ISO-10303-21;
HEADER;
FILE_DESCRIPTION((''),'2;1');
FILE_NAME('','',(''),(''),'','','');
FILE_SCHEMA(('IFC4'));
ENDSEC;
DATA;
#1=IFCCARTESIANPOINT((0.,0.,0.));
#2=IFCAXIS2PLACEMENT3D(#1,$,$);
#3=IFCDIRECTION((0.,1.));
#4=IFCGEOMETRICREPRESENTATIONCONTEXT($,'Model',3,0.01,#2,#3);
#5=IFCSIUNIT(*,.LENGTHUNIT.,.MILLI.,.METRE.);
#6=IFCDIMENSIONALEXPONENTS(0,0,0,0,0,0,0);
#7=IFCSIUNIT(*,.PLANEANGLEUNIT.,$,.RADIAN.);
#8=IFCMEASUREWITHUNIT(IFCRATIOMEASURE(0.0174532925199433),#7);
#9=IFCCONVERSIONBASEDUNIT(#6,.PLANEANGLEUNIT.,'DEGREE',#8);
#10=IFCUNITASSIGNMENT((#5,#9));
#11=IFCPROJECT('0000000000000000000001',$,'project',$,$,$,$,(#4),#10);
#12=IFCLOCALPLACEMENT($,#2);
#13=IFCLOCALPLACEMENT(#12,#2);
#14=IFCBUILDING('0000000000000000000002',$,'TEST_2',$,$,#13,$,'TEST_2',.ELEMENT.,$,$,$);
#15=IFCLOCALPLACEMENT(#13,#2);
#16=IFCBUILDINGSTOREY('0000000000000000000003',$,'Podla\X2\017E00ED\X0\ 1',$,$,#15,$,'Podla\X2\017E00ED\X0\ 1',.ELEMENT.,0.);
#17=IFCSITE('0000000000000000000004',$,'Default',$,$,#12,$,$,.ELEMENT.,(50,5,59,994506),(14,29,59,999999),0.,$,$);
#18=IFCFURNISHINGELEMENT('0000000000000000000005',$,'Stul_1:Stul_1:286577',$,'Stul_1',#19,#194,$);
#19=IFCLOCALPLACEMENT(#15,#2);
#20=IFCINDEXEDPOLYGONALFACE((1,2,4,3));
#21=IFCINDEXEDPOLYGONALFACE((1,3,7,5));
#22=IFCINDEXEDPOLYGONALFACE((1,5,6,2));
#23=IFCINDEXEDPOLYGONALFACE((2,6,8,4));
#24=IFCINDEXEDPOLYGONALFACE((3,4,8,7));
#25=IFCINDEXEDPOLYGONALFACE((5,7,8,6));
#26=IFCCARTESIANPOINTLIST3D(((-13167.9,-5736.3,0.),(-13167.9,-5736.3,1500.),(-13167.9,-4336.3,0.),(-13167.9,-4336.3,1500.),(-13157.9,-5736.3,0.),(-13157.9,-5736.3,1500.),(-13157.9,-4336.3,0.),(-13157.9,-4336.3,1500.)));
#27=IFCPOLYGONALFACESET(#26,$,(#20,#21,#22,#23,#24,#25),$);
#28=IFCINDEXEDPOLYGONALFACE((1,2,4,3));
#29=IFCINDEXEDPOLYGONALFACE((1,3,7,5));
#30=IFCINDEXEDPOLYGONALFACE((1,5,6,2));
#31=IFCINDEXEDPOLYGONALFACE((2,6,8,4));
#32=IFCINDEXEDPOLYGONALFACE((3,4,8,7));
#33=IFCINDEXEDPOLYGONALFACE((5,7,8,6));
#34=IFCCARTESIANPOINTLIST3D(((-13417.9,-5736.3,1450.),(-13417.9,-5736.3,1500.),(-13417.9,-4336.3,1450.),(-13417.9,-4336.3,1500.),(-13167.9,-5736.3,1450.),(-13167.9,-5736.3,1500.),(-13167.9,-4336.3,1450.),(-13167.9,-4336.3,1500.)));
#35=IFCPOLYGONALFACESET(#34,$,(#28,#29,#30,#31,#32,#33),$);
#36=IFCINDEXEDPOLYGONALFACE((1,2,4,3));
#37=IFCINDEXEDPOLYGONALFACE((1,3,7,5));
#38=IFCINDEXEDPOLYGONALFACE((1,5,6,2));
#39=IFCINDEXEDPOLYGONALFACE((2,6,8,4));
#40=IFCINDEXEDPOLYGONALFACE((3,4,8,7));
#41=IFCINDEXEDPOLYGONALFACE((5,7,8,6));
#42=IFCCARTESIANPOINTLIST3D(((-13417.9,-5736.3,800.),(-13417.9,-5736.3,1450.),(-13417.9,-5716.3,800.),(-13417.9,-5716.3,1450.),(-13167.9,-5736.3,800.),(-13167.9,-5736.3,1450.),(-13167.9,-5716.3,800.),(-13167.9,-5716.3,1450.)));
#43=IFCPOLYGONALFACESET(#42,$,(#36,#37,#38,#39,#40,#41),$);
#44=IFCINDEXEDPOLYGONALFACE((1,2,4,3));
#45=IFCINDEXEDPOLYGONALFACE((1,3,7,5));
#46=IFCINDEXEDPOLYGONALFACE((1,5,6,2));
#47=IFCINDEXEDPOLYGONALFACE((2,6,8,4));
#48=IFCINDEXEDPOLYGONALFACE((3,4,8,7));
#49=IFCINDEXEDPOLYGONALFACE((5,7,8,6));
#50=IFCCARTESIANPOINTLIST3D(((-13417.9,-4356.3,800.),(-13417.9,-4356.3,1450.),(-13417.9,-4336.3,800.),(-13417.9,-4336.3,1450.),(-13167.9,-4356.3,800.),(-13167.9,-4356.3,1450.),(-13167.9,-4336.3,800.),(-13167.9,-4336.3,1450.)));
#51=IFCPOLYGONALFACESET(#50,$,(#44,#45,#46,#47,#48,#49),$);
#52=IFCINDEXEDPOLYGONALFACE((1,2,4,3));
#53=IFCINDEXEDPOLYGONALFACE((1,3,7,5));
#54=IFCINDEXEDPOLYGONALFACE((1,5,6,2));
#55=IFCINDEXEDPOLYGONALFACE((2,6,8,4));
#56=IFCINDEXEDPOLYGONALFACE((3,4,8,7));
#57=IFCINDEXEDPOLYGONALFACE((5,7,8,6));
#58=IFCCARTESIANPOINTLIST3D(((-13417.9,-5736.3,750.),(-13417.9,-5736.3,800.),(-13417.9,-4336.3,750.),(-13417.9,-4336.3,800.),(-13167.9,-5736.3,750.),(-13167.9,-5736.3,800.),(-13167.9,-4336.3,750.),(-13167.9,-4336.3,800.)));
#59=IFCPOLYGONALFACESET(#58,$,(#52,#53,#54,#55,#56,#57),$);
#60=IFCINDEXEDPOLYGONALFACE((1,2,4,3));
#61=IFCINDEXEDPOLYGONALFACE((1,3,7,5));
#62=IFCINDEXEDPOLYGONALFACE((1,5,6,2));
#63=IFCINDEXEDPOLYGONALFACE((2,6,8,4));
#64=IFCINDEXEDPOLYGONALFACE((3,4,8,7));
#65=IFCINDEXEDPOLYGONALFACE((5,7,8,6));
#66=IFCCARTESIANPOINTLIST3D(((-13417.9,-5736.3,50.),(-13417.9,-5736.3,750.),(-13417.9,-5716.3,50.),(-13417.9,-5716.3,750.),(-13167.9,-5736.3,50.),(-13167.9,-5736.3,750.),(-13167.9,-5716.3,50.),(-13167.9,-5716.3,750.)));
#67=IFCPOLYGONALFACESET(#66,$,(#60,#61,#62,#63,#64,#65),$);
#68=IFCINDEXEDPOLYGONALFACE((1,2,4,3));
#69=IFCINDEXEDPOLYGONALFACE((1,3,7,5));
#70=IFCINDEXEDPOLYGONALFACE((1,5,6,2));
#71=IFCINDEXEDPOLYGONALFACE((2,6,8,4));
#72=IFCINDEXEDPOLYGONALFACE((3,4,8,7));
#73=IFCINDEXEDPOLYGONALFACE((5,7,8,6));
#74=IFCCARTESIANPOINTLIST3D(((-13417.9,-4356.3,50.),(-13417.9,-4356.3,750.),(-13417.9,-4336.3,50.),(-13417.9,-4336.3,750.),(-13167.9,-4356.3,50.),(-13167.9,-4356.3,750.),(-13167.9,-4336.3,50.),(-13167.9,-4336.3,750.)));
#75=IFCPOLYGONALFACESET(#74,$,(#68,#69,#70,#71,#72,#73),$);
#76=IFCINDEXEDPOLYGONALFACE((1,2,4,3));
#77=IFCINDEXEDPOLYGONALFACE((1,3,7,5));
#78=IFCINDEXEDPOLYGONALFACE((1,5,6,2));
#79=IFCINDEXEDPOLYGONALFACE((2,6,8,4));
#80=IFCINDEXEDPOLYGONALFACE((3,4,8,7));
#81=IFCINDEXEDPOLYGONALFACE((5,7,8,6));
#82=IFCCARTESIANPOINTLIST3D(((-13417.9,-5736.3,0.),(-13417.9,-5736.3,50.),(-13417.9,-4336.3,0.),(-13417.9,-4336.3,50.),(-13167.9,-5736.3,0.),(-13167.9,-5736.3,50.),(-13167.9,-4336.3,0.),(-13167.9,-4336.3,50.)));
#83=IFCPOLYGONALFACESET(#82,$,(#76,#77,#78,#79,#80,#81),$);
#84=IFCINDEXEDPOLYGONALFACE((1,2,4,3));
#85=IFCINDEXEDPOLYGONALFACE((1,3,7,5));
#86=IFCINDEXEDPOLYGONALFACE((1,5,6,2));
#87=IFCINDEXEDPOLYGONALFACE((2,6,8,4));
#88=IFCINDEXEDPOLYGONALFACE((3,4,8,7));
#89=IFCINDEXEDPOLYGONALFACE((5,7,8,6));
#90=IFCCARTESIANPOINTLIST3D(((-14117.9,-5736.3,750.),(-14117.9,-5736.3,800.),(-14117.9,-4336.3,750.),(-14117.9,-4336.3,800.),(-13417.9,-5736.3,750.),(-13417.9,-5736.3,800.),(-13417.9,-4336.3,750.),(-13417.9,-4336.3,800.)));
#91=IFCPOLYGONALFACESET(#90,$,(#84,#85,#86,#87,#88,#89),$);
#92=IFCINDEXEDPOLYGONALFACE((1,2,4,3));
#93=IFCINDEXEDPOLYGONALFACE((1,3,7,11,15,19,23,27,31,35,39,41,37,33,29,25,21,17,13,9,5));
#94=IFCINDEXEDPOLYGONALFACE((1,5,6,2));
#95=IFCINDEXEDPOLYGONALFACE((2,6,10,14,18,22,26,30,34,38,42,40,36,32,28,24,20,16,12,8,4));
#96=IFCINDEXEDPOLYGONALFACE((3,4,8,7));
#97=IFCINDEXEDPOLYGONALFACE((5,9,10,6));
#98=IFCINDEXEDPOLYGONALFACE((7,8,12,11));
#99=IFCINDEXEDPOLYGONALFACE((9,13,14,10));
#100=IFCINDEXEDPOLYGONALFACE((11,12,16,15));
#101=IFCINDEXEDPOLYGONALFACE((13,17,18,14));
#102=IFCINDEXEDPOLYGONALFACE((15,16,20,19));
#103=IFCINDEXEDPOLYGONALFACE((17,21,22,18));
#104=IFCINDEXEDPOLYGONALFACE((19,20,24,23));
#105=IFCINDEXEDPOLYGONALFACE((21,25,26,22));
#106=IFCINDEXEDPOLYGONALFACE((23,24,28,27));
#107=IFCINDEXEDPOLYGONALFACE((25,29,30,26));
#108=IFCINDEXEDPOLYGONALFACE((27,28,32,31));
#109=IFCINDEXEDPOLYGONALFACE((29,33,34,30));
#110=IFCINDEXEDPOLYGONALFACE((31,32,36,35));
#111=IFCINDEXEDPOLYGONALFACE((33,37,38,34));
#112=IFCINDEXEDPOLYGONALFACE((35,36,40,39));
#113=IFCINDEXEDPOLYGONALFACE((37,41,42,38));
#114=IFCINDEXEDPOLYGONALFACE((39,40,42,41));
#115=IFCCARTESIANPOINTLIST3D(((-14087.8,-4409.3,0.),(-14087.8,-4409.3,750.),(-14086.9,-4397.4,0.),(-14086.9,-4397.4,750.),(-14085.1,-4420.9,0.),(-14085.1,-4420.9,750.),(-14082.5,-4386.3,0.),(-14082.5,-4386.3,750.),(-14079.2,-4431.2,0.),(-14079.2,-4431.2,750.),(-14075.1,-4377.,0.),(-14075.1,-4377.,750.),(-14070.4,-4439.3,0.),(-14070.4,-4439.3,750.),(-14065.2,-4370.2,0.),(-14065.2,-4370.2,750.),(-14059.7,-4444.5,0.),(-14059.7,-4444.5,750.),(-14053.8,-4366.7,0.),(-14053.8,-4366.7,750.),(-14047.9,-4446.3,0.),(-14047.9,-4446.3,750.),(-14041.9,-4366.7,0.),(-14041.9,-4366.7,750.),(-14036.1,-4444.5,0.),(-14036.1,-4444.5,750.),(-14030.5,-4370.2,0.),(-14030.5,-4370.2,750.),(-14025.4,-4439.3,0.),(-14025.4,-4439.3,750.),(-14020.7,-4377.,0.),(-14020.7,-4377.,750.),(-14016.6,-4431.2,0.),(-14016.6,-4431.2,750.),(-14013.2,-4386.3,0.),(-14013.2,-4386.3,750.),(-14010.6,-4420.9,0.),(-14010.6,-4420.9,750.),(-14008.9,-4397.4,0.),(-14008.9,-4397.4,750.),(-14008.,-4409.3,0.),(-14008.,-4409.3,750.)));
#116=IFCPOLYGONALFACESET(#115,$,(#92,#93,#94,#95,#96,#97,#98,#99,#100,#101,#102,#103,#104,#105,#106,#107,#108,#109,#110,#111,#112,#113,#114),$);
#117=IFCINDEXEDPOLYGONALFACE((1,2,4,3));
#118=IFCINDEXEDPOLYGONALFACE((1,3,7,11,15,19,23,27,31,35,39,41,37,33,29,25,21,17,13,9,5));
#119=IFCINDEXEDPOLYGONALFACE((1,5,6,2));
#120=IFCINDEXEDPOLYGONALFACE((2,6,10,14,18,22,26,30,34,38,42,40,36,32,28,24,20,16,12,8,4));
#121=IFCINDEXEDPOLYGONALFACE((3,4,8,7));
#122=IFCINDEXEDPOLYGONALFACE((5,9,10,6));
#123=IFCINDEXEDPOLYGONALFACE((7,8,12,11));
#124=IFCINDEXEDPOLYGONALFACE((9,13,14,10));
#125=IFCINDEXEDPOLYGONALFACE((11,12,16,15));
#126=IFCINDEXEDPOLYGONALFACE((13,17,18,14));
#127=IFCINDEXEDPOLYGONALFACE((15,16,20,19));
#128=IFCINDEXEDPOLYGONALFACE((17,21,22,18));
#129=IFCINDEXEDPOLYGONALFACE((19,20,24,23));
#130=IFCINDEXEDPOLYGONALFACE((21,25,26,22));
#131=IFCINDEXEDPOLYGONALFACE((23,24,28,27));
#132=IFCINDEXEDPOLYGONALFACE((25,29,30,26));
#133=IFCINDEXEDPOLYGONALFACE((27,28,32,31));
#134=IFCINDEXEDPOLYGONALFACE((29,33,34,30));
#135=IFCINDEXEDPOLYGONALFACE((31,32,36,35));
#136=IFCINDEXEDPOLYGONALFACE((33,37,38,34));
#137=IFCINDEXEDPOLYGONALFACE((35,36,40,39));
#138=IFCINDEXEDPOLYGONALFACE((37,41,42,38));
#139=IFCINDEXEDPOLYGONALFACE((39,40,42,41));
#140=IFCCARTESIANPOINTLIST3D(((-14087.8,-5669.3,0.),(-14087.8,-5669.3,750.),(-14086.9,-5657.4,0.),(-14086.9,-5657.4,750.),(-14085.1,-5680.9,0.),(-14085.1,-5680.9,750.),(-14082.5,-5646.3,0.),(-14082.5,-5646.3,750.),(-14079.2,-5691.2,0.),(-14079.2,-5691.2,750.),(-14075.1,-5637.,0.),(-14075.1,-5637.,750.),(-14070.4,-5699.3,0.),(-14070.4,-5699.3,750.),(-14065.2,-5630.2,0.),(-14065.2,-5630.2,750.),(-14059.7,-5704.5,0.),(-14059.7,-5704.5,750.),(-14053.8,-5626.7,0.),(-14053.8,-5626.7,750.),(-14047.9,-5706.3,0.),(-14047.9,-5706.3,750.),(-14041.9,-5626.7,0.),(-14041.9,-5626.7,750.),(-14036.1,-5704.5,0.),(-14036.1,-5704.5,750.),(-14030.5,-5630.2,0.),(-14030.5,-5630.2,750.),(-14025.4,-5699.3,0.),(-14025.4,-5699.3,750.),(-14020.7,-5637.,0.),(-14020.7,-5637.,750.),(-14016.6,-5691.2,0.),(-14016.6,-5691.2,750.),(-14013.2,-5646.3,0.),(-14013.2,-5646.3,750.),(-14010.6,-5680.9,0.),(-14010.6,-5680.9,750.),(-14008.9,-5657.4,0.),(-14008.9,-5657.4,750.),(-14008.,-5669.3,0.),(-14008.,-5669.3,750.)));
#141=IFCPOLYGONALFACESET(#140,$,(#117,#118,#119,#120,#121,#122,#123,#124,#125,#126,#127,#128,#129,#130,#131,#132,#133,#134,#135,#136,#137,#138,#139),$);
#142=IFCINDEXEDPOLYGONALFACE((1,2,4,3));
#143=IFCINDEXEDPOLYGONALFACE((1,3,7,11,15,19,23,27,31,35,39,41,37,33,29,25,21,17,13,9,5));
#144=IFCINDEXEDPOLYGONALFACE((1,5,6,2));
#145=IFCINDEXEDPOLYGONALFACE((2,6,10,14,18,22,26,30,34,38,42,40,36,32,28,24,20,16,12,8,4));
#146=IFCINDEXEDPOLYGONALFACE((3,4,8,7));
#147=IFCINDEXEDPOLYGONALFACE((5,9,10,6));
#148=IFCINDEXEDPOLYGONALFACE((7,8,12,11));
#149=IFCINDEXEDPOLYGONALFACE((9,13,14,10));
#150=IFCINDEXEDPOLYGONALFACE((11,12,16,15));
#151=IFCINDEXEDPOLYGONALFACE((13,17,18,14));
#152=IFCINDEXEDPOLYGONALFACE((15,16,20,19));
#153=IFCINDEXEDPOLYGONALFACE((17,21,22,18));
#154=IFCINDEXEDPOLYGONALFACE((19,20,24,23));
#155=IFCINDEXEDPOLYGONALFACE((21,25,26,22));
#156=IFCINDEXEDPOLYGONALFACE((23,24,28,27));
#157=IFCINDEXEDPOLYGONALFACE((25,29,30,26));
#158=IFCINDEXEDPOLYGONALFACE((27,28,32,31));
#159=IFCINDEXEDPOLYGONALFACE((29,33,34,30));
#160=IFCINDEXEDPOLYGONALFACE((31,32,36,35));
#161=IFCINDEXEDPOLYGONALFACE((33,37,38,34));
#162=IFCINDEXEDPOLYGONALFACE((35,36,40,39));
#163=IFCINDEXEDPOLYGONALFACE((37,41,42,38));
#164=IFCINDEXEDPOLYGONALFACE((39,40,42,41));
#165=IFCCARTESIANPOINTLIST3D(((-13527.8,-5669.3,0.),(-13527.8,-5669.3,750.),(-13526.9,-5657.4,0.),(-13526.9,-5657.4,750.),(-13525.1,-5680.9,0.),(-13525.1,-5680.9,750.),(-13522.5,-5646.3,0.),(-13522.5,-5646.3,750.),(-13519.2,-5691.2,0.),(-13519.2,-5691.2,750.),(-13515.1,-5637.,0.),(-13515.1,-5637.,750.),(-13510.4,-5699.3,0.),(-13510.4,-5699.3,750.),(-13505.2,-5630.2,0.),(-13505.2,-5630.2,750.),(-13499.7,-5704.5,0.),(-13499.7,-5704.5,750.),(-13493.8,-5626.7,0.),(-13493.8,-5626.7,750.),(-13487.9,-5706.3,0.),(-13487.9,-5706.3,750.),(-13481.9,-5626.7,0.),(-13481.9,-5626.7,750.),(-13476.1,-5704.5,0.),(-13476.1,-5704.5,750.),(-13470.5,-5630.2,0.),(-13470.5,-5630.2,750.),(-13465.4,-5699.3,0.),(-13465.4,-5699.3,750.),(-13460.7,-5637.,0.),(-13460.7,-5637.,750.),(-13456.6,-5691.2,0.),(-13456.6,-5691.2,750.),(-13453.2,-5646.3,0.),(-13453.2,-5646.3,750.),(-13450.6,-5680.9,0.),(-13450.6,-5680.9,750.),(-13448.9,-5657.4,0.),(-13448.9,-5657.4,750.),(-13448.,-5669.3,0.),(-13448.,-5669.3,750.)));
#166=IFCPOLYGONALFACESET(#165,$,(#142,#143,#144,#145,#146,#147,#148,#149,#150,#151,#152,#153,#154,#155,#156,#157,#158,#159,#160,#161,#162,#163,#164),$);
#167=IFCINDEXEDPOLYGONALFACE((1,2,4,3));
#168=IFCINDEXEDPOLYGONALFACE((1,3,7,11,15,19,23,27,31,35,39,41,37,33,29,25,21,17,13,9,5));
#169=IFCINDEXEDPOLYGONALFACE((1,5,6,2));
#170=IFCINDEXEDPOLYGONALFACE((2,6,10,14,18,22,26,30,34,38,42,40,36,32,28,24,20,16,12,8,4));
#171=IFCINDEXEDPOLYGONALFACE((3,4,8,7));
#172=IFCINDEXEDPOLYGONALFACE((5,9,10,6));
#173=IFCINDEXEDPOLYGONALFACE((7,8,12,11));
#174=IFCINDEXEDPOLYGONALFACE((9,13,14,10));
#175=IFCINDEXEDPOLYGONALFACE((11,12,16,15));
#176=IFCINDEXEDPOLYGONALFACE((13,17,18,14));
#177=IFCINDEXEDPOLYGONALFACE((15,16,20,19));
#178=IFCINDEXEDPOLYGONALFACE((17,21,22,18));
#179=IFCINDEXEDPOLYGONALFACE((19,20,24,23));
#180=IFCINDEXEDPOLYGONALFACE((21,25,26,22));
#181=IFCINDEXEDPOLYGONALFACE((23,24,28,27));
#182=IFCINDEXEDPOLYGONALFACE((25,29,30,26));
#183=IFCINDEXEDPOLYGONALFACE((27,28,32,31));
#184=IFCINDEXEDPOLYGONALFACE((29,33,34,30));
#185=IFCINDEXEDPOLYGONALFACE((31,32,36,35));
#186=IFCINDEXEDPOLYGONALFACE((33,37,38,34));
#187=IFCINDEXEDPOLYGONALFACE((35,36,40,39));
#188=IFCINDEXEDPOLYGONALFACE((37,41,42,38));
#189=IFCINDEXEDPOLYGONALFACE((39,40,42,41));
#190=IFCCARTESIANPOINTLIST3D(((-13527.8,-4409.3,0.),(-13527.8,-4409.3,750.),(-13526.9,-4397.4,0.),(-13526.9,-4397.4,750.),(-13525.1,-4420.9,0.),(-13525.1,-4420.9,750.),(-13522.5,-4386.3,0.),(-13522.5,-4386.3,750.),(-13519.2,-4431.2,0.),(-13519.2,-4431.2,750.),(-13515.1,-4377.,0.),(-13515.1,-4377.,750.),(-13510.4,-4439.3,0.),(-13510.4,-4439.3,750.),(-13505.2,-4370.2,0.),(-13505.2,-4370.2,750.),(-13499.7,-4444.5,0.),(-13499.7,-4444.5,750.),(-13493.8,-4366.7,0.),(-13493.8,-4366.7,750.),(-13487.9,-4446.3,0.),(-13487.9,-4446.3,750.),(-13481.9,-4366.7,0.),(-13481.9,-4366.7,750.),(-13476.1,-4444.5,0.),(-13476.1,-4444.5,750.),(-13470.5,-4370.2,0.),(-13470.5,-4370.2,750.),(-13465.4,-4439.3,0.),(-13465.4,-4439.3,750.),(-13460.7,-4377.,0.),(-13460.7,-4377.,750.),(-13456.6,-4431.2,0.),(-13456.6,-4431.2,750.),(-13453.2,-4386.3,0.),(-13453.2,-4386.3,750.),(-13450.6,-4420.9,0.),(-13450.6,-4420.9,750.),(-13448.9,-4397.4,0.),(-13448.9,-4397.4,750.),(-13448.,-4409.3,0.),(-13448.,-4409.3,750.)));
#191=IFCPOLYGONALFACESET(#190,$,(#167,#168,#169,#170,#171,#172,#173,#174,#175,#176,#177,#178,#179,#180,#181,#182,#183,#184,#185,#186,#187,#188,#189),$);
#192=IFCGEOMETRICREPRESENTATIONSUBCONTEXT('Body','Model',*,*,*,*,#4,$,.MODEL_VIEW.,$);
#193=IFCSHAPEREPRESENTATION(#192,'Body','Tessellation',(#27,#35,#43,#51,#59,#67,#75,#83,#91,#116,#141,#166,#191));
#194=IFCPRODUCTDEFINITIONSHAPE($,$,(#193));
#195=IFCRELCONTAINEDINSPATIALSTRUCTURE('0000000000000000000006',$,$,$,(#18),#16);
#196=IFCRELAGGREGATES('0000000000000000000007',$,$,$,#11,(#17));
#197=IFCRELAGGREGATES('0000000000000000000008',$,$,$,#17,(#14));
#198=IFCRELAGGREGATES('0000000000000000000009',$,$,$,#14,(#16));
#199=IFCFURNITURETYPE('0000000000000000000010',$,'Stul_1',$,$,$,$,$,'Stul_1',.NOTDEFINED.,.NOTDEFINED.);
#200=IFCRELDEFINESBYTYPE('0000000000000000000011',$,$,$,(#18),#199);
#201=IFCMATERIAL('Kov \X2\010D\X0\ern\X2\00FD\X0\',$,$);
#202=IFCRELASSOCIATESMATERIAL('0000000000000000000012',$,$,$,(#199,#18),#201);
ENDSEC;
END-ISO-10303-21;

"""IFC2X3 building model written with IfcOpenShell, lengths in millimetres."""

from ifc_helpers import new_model, entity, si_unit, converted_unit, direction, frame, frame_2d, origin, origin_2d_with_axis, place, context, subcontext, project, spatial, rectangle, circle, extrude, source, transform, mapped, material, type_object, type_shapes, element, save


model = new_model("IFC2X3")

# Units and contexts
model_context = context("Model", 3, precision=0.01, world=origin(), true_north=direction((0.0, 1.0)))
body_context = subcontext(model_context, "Body", "Model", "MODEL_VIEW")
ifc_project = project(units=[si_unit("LENGTHUNIT", "METRE", prefix="MILLI"), converted_unit("PLANEANGLEUNIT", "DEGREE", entity("IfcRatioMeasure", 0.0174532925199433), si_unit("PLANEANGLEUNIT", "RADIAN"), dimensions=[0, 0, 0, 0, 0, 0, 0])], contexts=[model_context])

# Site, building, storey
site_placement = place(None, origin())
site = spatial("IfcSite", under=ifc_project, at=site_placement, Name="Default", CompositionType="ELEMENT", RefLatitude=(50, 5, 59, 994506), RefLongitude=(14, 29, 59, 999999), RefElevation=0.0)
building_placement = place(site_placement, origin())
building = spatial("IfcBuilding", under=site, at=building_placement, Name="TEST_2", LongName="TEST_2", CompositionType="ELEMENT")
storey_placement = place(building_placement, origin())
storey = spatial("IfcBuildingStorey", under=building, at=storey_placement, Name="Podlaží 1", LongName="Podlaží 1", CompositionType="ELEMENT", Elevation=0.0)

# Furnishing element
ifc_material_1 = material(Name="Kov černý")
furniture_type = type_object("IfcFurnitureType", Name="Stul_1", ElementType="Stul_1", material=ifc_material_1)
shared_shape_1 = source(origin(), body_context, "Body", "SweptSolid", [
    extrude(rectangle(XDim=1400.0, YDim=10.0, at=origin_2d_with_axis()), frame((0.0, 605.0, 0.0), z_axis=(0.0, 0.0, 1.0), x_axis=(-1.0, 0.0, 0.0)), (0.0, 0.0, 1.0), 1500.0),
    extrude(rectangle(XDim=1400.0, YDim=250.0, at=frame_2d((0.0, 0.0), x_axis=(1.0, 0.0))), frame((0.0, 475.0, 1450.0), z_axis=(0.0, 0.0, 1.0), x_axis=(-1.0, 0.0, 0.0)), (0.0, 0.0, 1.0), 50.0),
    extrude(rectangle(XDim=20.0, YDim=250.0, at=origin_2d_with_axis()), frame((690.0, 475.0, 800.0), z_axis=(0.0, 0.0, 1.0), x_axis=(-1.0, 0.0, 0.0)), (0.0, 0.0, 1.0), 650.0),
    extrude(rectangle(XDim=20.0, YDim=250.0, at=frame_2d((0.0, 0.0), x_axis=(1.0, 0.0))), frame((-690.0, 475.0, 800.0), z_axis=(0.0, 0.0, 1.0), x_axis=(-1.0, 0.0, 0.0)), (0.0, 0.0, 1.0), 650.0),
    extrude(rectangle(XDim=1400.0, YDim=250.0, at=origin_2d_with_axis()), frame((0.0, 475.0, 750.0), z_axis=(0.0, 0.0, 1.0), x_axis=(-1.0, 0.0, 0.0)), (0.0, 0.0, 1.0), 50.0),
    extrude(rectangle(XDim=20.0, YDim=250.0, at=origin_2d_with_axis()), frame((690.0, 475.0, 50.0), z_axis=(0.0, 0.0, 1.0), x_axis=(-1.0, 0.0, 0.0)), (0.0, 0.0, 1.0), 700.0),
    extrude(rectangle(XDim=20.0, YDim=250.0, at=frame_2d((0.0, 0.0), x_axis=(1.0, 0.0))), frame((-690.0, 475.0, 50.0), z_axis=(0.0, 0.0, 1.0), x_axis=(-1.0, 0.0, 0.0)), (0.0, 0.0, 1.0), 700.0),
    extrude(rectangle(XDim=1400.0, YDim=250.0, at=origin_2d_with_axis()), frame((0.0, 475.0, 0.0), z_axis=(0.0, 0.0, 1.0), x_axis=(-1.0, 0.0, 0.0)), (0.0, 0.0, 1.0), 50.0),
    extrude(rectangle(XDim=1400.0, YDim=700.0, at=origin_2d_with_axis()), frame((0.0, 0.0, 750.0), z_axis=(0.0, 0.0, 1.0), x_axis=(-1.0, 0.0, 0.0)), (0.0, 0.0, 1.0), 50.0),
    extrude(circle(Radius=40.0, at=frame_2d((0.0, 0.0), x_axis=(1.0, 0.0))), frame((-630.0, -280.0, 0.0)), (0.0, 0.0, 1.0), 750.0),
    extrude(circle(Radius=40.0, at=frame_2d((0.0, 0.0), x_axis=(1.0, 0.0))), frame((630.0, -280.0, 0.0)), (0.0, 0.0, 1.0), 750.0),
    extrude(circle(Radius=40.0, at=frame_2d((0.0, 0.0), x_axis=(1.0, 0.0))), frame((630.0, 280.0, 0.0)), (0.0, 0.0, 1.0), 750.0),
    extrude(circle(Radius=40.0, at=frame_2d((0.0, 0.0), x_axis=(1.0, 0.0))), frame((-630.0, 280.0, 0.0)), (0.0, 0.0, 1.0), 750.0),
])
type_shapes(furniture_type, [shared_shape_1])
for number, where, z_axis, x_axis, name in (
    (1, (-13767.9, -5036.3, 0.0), (0.0, 0.0, 1.0), (0.0, -1.0, 0.0), "Stul_1:Stul_1:286577"),
):
    element("IfcFurnishingElement", number, at=place(storey_placement, frame(where, z_axis=z_axis, x_axis=x_axis)), inside=storey, type_object=furniture_type, material=ifc_material_1, Name=name, ObjectType="Stul_1", context=body_context, shape_type="MappedRepresentation", body=[
        mapped(shared_shape_1, transform((0.0, 0.0, 0.0), scale=1.0)),
    ])

save(model, "model.ifc")
